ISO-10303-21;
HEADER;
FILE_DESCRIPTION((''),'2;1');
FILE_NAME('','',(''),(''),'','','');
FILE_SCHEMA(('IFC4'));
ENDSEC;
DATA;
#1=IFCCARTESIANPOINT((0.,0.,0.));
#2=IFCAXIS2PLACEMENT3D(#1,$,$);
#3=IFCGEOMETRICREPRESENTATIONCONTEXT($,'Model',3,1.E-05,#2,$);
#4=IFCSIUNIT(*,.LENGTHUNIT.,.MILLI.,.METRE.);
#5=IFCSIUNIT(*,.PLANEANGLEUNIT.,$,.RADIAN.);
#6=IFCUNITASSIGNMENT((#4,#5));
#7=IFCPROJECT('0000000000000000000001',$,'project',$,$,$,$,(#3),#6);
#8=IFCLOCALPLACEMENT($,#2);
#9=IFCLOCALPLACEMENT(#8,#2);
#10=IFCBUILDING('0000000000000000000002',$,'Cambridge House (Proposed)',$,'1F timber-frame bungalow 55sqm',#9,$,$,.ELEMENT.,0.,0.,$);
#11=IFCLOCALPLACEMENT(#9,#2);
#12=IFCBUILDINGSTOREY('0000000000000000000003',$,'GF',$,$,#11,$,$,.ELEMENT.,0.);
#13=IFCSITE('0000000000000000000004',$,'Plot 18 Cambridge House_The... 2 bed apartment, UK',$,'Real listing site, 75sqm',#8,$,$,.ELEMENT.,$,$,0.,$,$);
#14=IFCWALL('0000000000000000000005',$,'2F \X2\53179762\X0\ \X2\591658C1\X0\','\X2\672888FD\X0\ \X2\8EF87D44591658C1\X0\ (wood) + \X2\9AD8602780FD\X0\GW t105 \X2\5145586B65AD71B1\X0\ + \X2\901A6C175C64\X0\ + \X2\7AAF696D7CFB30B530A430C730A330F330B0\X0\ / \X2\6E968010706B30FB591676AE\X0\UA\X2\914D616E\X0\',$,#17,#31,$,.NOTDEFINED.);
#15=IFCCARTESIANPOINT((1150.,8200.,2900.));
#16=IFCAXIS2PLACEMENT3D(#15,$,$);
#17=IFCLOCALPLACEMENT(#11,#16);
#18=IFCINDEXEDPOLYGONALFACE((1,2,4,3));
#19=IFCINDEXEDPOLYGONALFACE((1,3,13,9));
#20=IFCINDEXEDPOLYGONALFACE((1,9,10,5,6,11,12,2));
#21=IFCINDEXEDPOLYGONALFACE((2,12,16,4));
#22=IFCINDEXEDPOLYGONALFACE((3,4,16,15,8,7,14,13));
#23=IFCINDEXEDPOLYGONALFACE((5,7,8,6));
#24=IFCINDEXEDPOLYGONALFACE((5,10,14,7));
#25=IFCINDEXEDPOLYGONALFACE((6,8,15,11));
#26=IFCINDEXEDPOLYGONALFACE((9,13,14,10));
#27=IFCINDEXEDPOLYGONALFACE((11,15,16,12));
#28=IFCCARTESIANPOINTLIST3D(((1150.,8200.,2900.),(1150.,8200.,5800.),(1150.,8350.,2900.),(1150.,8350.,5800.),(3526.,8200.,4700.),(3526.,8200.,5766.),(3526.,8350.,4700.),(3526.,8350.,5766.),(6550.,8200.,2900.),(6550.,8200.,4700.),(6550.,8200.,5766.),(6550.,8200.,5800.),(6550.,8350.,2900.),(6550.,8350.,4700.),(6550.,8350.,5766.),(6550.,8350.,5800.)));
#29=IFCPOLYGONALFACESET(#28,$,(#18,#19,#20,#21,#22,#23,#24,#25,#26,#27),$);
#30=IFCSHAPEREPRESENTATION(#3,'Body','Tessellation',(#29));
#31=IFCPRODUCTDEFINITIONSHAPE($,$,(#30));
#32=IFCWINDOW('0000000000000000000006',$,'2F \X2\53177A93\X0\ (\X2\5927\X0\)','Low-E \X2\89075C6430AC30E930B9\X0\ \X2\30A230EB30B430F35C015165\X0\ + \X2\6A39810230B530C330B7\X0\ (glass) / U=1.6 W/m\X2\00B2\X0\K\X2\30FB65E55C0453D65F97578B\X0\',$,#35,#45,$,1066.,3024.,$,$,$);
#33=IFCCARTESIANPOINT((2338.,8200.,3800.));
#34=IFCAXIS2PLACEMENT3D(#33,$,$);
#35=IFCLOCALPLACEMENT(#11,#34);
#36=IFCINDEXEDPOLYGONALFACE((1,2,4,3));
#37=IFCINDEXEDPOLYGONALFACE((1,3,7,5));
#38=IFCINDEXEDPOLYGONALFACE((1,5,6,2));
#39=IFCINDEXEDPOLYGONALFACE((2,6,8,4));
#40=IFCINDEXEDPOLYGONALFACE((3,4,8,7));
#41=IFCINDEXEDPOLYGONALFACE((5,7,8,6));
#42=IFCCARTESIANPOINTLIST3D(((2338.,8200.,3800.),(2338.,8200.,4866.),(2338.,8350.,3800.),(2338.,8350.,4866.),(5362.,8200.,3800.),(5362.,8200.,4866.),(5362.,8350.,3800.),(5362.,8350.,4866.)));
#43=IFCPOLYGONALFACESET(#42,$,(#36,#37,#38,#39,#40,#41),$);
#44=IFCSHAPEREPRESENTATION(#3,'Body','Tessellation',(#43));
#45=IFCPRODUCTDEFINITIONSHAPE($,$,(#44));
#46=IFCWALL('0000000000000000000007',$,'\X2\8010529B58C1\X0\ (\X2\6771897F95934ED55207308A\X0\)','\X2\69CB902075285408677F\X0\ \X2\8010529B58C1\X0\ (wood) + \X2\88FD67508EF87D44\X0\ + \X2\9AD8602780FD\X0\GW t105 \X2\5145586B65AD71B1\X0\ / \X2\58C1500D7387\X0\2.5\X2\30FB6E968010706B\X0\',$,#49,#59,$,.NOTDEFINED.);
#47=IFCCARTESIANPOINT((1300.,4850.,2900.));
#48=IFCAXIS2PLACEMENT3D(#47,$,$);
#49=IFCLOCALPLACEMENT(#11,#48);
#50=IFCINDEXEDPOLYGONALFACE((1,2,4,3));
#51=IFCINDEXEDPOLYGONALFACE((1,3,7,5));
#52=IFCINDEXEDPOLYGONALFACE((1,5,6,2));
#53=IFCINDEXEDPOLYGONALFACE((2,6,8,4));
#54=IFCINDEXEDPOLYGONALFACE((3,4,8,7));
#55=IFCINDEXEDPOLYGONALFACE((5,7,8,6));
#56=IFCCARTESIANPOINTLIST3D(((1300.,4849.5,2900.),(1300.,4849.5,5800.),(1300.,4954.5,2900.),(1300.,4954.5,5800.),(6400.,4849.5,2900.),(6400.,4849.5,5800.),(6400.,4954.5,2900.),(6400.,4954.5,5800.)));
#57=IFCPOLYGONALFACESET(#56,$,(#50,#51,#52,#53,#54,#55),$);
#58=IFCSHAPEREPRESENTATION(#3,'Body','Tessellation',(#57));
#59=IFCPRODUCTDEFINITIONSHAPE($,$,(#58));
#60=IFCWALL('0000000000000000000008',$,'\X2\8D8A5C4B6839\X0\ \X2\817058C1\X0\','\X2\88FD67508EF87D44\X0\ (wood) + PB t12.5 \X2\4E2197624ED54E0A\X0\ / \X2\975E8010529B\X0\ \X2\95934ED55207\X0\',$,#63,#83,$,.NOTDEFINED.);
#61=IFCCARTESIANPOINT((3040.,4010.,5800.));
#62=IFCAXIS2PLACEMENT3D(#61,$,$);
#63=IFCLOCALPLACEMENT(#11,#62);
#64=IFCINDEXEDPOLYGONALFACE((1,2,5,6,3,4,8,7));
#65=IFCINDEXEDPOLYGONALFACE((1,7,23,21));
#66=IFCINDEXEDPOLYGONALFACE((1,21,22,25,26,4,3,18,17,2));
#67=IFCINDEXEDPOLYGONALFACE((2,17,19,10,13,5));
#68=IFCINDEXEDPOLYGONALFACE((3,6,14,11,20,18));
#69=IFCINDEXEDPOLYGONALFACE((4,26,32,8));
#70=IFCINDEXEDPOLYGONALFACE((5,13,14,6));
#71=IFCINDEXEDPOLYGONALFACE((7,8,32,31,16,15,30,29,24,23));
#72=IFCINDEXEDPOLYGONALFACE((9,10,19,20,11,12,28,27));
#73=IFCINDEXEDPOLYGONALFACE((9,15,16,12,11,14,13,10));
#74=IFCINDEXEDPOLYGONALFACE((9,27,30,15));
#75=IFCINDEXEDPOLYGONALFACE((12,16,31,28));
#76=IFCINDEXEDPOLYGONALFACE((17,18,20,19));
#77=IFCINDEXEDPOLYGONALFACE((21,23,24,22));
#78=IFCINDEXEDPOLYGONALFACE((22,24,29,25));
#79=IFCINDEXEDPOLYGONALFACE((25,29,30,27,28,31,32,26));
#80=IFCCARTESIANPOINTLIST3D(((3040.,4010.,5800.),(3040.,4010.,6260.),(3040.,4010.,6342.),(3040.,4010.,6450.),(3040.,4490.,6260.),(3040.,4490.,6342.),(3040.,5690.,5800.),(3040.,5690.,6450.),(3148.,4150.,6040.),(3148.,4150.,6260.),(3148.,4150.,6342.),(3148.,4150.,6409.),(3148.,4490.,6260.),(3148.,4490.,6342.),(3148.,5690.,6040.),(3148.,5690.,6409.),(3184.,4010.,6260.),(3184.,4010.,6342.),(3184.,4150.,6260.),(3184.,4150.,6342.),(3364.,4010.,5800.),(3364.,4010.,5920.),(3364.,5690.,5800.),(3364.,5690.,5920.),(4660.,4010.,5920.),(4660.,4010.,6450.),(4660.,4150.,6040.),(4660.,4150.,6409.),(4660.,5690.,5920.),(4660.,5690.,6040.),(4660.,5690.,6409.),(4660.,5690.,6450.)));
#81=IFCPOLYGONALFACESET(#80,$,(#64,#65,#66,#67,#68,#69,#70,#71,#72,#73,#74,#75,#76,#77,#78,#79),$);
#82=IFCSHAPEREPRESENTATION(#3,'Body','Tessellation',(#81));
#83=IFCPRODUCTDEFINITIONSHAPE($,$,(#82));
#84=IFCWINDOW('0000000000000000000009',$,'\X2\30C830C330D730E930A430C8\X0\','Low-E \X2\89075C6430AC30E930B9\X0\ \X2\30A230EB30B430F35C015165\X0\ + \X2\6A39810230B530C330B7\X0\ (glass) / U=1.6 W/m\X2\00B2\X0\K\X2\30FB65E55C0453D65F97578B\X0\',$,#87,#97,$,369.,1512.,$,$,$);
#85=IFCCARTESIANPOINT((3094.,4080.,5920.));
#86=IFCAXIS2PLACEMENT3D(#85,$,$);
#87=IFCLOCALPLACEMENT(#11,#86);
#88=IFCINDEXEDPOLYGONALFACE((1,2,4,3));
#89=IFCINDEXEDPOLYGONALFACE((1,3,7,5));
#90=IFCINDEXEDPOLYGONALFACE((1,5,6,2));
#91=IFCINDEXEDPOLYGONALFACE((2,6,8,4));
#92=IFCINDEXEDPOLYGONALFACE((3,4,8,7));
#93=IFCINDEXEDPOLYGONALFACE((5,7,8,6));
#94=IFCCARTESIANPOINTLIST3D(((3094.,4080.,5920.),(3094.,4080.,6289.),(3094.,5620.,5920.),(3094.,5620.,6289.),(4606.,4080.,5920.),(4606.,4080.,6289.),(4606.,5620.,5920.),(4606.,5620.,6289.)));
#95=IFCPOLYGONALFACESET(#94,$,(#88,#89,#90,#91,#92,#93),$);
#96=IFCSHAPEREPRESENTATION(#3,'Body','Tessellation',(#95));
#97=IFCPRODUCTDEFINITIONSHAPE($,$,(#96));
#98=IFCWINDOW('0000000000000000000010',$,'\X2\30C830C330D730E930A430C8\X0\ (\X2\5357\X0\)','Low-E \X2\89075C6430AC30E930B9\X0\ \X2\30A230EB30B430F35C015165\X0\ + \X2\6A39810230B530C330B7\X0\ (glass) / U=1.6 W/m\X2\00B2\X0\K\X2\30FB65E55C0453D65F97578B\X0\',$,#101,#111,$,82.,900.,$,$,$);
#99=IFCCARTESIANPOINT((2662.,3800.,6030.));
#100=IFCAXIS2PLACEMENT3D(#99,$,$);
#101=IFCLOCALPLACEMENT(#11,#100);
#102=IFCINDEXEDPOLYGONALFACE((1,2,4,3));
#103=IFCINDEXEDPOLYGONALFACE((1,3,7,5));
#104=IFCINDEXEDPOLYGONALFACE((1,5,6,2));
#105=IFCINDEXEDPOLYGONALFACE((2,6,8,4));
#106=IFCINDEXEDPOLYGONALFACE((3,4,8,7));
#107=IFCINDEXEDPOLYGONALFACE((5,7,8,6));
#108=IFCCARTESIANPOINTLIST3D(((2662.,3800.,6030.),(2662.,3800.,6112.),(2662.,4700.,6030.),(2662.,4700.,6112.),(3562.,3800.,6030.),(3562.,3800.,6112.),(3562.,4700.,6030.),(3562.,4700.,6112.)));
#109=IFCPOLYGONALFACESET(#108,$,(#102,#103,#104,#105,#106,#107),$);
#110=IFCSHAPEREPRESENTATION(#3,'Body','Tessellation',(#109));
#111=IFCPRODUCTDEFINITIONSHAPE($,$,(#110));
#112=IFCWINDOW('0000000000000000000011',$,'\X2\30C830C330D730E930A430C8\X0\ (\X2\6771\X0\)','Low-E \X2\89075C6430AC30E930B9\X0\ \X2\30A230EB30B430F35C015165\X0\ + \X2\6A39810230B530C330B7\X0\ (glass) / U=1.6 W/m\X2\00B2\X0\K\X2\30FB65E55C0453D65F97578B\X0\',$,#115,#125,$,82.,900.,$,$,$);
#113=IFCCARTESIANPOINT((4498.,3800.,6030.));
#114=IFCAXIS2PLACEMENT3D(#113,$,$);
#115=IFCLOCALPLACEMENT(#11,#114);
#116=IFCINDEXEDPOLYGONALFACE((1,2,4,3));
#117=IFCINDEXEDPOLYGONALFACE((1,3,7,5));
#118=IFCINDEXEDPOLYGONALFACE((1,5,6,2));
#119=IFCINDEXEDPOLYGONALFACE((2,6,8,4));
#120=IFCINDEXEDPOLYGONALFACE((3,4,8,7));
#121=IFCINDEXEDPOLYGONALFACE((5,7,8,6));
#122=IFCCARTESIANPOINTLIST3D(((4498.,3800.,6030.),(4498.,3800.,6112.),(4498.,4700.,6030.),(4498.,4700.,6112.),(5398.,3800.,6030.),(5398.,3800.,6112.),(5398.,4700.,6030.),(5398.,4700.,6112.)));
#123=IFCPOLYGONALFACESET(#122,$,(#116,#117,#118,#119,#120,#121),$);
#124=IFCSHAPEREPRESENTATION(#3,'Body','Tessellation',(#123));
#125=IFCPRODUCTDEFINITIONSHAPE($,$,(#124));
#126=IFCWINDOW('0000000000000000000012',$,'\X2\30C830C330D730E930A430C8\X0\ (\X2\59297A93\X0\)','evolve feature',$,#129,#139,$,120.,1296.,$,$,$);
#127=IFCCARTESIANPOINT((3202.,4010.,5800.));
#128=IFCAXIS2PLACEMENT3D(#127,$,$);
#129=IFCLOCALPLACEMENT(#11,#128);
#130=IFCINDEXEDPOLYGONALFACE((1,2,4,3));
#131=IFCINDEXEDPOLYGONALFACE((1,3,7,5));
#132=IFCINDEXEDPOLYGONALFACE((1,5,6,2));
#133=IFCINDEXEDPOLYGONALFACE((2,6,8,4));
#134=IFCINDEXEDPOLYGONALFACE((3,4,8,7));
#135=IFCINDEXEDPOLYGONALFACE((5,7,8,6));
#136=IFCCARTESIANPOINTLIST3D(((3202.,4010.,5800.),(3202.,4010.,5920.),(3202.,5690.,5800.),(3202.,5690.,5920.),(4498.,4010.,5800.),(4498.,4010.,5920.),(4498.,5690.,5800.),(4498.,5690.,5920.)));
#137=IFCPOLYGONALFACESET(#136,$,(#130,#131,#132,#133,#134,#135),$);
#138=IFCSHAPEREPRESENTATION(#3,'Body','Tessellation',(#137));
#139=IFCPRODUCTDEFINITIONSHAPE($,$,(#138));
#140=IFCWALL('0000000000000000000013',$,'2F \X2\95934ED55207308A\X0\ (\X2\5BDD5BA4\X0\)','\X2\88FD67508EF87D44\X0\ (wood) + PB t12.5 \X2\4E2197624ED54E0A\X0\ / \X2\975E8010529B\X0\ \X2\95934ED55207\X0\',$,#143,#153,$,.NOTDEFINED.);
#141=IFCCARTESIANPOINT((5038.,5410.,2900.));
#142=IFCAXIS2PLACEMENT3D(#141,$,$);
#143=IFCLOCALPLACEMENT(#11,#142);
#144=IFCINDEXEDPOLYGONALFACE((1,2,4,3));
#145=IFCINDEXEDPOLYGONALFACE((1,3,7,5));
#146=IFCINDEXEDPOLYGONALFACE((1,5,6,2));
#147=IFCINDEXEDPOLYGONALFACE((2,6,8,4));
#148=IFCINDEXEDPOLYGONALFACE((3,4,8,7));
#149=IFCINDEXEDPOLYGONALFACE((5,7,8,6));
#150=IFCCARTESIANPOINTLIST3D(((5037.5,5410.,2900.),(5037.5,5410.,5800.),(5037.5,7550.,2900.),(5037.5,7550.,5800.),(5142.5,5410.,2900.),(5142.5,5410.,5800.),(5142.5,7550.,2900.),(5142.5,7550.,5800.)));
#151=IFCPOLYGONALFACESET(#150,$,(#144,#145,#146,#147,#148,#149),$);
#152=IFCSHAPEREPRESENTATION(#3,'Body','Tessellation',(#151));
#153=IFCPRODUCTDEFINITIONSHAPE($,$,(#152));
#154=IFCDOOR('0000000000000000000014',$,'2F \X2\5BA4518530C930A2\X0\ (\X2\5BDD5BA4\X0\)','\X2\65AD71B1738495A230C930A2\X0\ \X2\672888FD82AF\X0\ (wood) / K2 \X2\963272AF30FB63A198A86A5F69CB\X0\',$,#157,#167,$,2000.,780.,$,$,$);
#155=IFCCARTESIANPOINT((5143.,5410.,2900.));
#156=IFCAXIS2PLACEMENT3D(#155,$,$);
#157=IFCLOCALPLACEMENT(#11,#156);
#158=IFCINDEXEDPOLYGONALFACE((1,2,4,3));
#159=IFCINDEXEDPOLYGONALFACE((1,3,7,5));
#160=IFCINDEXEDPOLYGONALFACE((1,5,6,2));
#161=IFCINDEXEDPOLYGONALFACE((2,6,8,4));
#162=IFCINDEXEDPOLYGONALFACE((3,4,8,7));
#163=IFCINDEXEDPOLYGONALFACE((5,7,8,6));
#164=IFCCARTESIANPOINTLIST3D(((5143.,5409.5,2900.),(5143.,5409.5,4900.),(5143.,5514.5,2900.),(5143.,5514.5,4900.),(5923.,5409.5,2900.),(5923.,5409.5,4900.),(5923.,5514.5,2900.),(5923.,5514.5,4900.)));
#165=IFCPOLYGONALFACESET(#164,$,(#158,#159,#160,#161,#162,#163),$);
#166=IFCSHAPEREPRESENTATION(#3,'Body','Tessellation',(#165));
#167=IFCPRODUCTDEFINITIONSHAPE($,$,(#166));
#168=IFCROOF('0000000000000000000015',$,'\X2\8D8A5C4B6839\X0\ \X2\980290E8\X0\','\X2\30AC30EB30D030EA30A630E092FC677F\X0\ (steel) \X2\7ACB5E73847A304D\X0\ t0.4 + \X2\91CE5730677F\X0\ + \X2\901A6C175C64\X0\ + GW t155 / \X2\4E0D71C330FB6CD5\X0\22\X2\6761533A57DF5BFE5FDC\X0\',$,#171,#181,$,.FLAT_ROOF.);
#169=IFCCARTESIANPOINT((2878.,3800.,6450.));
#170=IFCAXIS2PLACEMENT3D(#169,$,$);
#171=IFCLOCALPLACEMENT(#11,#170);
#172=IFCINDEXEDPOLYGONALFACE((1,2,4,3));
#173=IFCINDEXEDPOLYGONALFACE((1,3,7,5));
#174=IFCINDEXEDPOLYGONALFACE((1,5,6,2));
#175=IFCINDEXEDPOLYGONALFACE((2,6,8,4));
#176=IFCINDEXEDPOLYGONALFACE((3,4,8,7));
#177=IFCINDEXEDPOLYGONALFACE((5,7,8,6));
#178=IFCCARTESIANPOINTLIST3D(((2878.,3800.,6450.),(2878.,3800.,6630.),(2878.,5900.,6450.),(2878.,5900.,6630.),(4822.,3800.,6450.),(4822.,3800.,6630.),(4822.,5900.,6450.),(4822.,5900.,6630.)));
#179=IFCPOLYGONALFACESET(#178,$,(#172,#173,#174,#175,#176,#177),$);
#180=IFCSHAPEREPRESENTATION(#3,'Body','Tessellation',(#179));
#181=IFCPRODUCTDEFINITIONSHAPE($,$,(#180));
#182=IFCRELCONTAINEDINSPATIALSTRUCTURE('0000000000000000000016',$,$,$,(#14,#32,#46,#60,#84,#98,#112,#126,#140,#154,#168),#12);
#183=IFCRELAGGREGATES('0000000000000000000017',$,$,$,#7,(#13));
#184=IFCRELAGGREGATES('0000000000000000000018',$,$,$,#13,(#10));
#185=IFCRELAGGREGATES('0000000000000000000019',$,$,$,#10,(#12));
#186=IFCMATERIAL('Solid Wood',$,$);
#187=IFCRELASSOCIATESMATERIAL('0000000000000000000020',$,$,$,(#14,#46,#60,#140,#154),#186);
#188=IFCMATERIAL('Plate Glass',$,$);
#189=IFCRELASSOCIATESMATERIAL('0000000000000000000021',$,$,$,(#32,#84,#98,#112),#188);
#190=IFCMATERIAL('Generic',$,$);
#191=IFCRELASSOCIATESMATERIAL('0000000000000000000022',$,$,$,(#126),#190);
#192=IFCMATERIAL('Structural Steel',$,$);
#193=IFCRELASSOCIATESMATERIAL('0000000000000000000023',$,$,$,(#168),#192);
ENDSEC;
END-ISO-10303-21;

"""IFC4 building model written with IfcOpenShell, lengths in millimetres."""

from ifc_helpers import new_model, si_unit, frame, frame_2d, origin, place, context, project, spatial, rectangle, extrude, material, element, fill, save


model = new_model("IFC4")

# Units and contexts
model_context = context("Model", 3, precision=1e-05, world=origin())
ifc_project = project(units=[si_unit("LENGTHUNIT", "METRE", prefix="MILLI"), si_unit("PLANEANGLEUNIT", "RADIAN")], contexts=[model_context])

# Site, building, storey
site_placement = place(None, origin())
site = spatial("IfcSite", under=ifc_project, at=site_placement, Name="Plot 18 Cambridge House_The... 2 bed apartment, UK", ObjectType="Real listing site, 75sqm", CompositionType="ELEMENT", RefElevation=0.0)
building_placement = place(site_placement, origin())
building = spatial("IfcBuilding", under=site, at=building_placement, Name="Cambridge House (Proposed)", ObjectType="1F timber-frame bungalow 55sqm", CompositionType="ELEMENT", ElevationOfRefHeight=0.0, ElevationOfTerrain=0.0)
storey_placement = place(building_placement, origin())
storey = spatial("IfcBuildingStorey", under=building, at=storey_placement, Name="GF", CompositionType="ELEMENT", Elevation=0.0)

# Wall, opening, window
ifc_material_1 = material(Name="Solid Wood")
wall_1_placement = place(storey_placement, frame((1150.0, 8200.0, 2900.0)))
wall_1 = element("IfcWall", 1, at=wall_1_placement, inside=storey, material=ifc_material_1, Name="2F 北面 外壁", Description="木製 軸組外壁 (wood) + 高性能GW t105 充填断熱 + 通気層 + 窯業系サイディング / 準耐火・外皮UA配慮", PredefinedType="NOTDEFINED", context=model_context, shape_type="SweptSolid", body=[
    extrude(rectangle(XDim=5400.0, YDim=150.0, at=frame_2d((2700.0, 75.0))), frame((1150.0, 8200.0, 2900.0)), (0.0, 0.0, 1.0), 2900.0),
])
opening_1_placement = place(storey_placement, frame((2338.0, 8200.0, 3800.0)))
opening_1 = element("IfcOpeningElement", 2, at=opening_1_placement, cuts=wall_1, PredefinedType="NOTDEFINED", context=model_context, shape_type="SweptSolid", body=[
    extrude(rectangle(XDim=3024.0, YDim=150.0, at=frame_2d((1512.0, 75.0))), frame((2338.0, 8200.0, 3800.0)), (0.0, 0.0, 1.0), 1066.0),
])
ifc_material_2 = material(Name="Plate Glass")
window_1_placement = place(storey_placement, frame((2338.0, 8200.0, 3800.0)))
window_1 = element("IfcWindow", 3, at=window_1_placement, inside=storey, material=ifc_material_2, Name="2F 北窓 (大)", Description="Low-E 複層ガラス アルゴン封入 + 樹脂サッシ (glass) / U=1.6 W/m²K・日射取得型", OverallHeight=1066.0, OverallWidth=3024.0, context=model_context, shape_type="SweptSolid", body=[
    extrude(rectangle(XDim=3024.0, YDim=150.0, at=frame_2d((1512.0, 75.0))), frame((2338.0, 8200.0, 3800.0)), (0.0, 0.0, 1.0), 1066.0),
])
fill(opening_1, window_1)

# Wall
wall_2_placement = place(storey_placement, frame((1300.0, 4850.0, 2900.0)))
element("IfcWall", 4, at=wall_2_placement, inside=storey, material=ifc_material_1, Name="耐力壁 (東西間仕切り)", Description="構造用合板 耐力壁 (wood) + 製材軸組 + 高性能GW t105 充填断熱 / 壁倍率2.5・準耐火", PredefinedType="NOTDEFINED", context=model_context, shape_type="SweptSolid", body=[
    extrude(rectangle(XDim=5100.0, YDim=105.0, at=frame_2d((2550.0, 52.0))), frame((1300.0, 4850.0, 2900.0)), (0.0, 0.0, 1.0), 2900.0),
])

# Wall, openings, windows
wall_3_placement = place(storey_placement, frame((3040.0, 4010.0, 5800.0)))
wall_3 = element("IfcWall", 5, at=wall_3_placement, inside=storey, material=ifc_material_1, Name="越屋根 腰壁", Description="製材軸組 (wood) + PB t12.5 両面仕上 / 非耐力 間仕切", PredefinedType="NOTDEFINED", context=model_context, shape_type="SweptSolid", body=[
    extrude(rectangle(XDim=1620.0, YDim=1680.0, at=frame_2d((810.0, 840.0))), frame((3040.0, 4010.0, 5800.0)), (0.0, 0.0, 1.0), 650.0),
])
opening_2_placement = place(storey_placement, frame((3094.0, 4080.0, 5920.0)))
opening_2 = element("IfcOpeningElement", 6, at=opening_2_placement, cuts=wall_3, PredefinedType="NOTDEFINED", context=model_context, shape_type="SweptSolid", body=[
    extrude(rectangle(XDim=1512.0, YDim=1540.0, at=frame_2d((756.0, 770.0))), frame((3094.0, 4080.0, 5920.0)), (0.0, 0.0, 1.0), 369.0),
])
opening_3_placement = place(storey_placement, frame((2662.0, 3800.0, 6030.0)))
opening_3 = element("IfcOpeningElement", 7, at=opening_3_placement, cuts=wall_3, PredefinedType="NOTDEFINED", context=model_context, shape_type="SweptSolid", body=[
    extrude(rectangle(XDim=900.0, YDim=900.0, at=frame_2d((450.0, 450.0))), frame((2662.0, 3800.0, 6030.0)), (0.0, 0.0, 1.0), 82.0),
])
opening_4_placement = place(storey_placement, frame((4498.0, 3800.0, 6030.0)))
opening_4 = element("IfcOpeningElement", 8, at=opening_4_placement, cuts=wall_3, PredefinedType="NOTDEFINED", context=model_context, shape_type="SweptSolid", body=[
    extrude(rectangle(XDim=900.0, YDim=900.0, at=frame_2d((450.0, 450.0))), frame((4498.0, 3800.0, 6030.0)), (0.0, 0.0, 1.0), 82.0),
])
opening_5_placement = place(storey_placement, frame((3202.0, 4010.0, 5800.0)))
opening_5 = element("IfcOpeningElement", 9, at=opening_5_placement, cuts=wall_3, PredefinedType="NOTDEFINED", context=model_context, shape_type="SweptSolid", body=[
    extrude(rectangle(XDim=1296.0, YDim=1680.0, at=frame_2d((648.0, 840.0))), frame((3202.0, 4010.0, 5800.0)), (0.0, 0.0, 1.0), 120.0),
])
window_2_placement = place(storey_placement, frame((3094.0, 4080.0, 5920.0)))
window_2 = element("IfcWindow", 10, at=window_2_placement, inside=storey, material=ifc_material_2, Name="トップライト", Description="Low-E 複層ガラス アルゴン封入 + 樹脂サッシ (glass) / U=1.6 W/m²K・日射取得型", OverallHeight=369.0, OverallWidth=1512.0, context=model_context, shape_type="SweptSolid", body=[
    extrude(rectangle(XDim=1512.0, YDim=1540.0, at=frame_2d((756.0, 770.0))), frame((3094.0, 4080.0, 5920.0)), (0.0, 0.0, 1.0), 369.0),
])
fill(opening_2, window_2)
window_3_placement = place(storey_placement, frame((2662.0, 3800.0, 6030.0)))
window_3 = element("IfcWindow", 11, at=window_3_placement, inside=storey, material=ifc_material_2, Name="トップライト (南)", Description="Low-E 複層ガラス アルゴン封入 + 樹脂サッシ (glass) / U=1.6 W/m²K・日射取得型", OverallHeight=82.0, OverallWidth=900.0, context=model_context, shape_type="SweptSolid", body=[
    extrude(rectangle(XDim=900.0, YDim=900.0, at=frame_2d((450.0, 450.0))), frame((2662.0, 3800.0, 6030.0)), (0.0, 0.0, 1.0), 82.0),
])
fill(opening_3, window_3)
window_4_placement = place(storey_placement, frame((4498.0, 3800.0, 6030.0)))
window_4 = element("IfcWindow", 12, at=window_4_placement, inside=storey, material=ifc_material_2, Name="トップライト (東)", Description="Low-E 複層ガラス アルゴン封入 + 樹脂サッシ (glass) / U=1.6 W/m²K・日射取得型", OverallHeight=82.0, OverallWidth=900.0, context=model_context, shape_type="SweptSolid", body=[
    extrude(rectangle(XDim=900.0, YDim=900.0, at=frame_2d((450.0, 450.0))), frame((4498.0, 3800.0, 6030.0)), (0.0, 0.0, 1.0), 82.0),
])
fill(opening_4, window_4)
ifc_material_3 = material(Name="Generic")
window_5_placement = place(storey_placement, frame((3202.0, 4010.0, 5800.0)))
window_5 = element("IfcWindow", 13, at=window_5_placement, inside=storey, material=ifc_material_3, Name="トップライト (天窓)", Description="evolve feature", OverallHeight=120.0, OverallWidth=1296.0, context=model_context, shape_type="SweptSolid", body=[
    extrude(rectangle(XDim=1296.0, YDim=1680.0, at=frame_2d((648.0, 840.0))), frame((3202.0, 4010.0, 5800.0)), (0.0, 0.0, 1.0), 120.0),
])
fill(opening_5, window_5)

# Wall
wall_4_placement = place(storey_placement, frame((5038.0, 5410.0, 2900.0)))
element("IfcWall", 14, at=wall_4_placement, inside=storey, material=ifc_material_1, Name="2F 間仕切り (寝室)", Description="製材軸組 (wood) + PB t12.5 両面仕上 / 非耐力 間仕切", PredefinedType="NOTDEFINED", context=model_context, shape_type="SweptSolid", body=[
    extrude(rectangle(XDim=105.0, YDim=2140.0, at=frame_2d((52.0, 1070.0))), frame((5038.0, 5410.0, 2900.0)), (0.0, 0.0, 1.0), 2900.0),
])

# Door
door_placement = place(storey_placement, frame((5143.0, 5410.0, 2900.0)))
element("IfcDoor", 15, at=door_placement, inside=storey, material=ifc_material_1, Name="2F 室内ドア (寝室)", Description="断熱玄関ドア 木製芯 (wood) / K2 防犯・採風機構", OverallHeight=2000.0, OverallWidth=780.0, context=model_context, shape_type="SweptSolid", body=[
    extrude(rectangle(XDim=780.0, YDim=105.0, at=frame_2d((390.0, 52.0))), frame((5143.0, 5410.0, 2900.0)), (0.0, 0.0, 1.0), 2000.0),
])

# Roof
ifc_material_4 = material(Name="Structural Steel")
roof_placement = place(storey_placement, frame((2878.0, 3800.0, 6450.0)))
element("IfcRoof", 16, at=roof_placement, inside=storey, material=ifc_material_4, Name="越屋根 頂部", Description="ガルバリウム鋼板 (steel) 立平葺き t0.4 + 野地板 + 通気層 + GW t155 / 不燃・法22条区域対応", PredefinedType="FLAT_ROOF", context=model_context, shape_type="SweptSolid", body=[
    extrude(rectangle(XDim=1944.0, YDim=2100.0, at=frame_2d((972.0, 1050.0))), frame((2878.0, 3800.0, 6450.0)), (0.0, 0.0, 1.0), 180.0),
])

save(model, "model.ifc")
